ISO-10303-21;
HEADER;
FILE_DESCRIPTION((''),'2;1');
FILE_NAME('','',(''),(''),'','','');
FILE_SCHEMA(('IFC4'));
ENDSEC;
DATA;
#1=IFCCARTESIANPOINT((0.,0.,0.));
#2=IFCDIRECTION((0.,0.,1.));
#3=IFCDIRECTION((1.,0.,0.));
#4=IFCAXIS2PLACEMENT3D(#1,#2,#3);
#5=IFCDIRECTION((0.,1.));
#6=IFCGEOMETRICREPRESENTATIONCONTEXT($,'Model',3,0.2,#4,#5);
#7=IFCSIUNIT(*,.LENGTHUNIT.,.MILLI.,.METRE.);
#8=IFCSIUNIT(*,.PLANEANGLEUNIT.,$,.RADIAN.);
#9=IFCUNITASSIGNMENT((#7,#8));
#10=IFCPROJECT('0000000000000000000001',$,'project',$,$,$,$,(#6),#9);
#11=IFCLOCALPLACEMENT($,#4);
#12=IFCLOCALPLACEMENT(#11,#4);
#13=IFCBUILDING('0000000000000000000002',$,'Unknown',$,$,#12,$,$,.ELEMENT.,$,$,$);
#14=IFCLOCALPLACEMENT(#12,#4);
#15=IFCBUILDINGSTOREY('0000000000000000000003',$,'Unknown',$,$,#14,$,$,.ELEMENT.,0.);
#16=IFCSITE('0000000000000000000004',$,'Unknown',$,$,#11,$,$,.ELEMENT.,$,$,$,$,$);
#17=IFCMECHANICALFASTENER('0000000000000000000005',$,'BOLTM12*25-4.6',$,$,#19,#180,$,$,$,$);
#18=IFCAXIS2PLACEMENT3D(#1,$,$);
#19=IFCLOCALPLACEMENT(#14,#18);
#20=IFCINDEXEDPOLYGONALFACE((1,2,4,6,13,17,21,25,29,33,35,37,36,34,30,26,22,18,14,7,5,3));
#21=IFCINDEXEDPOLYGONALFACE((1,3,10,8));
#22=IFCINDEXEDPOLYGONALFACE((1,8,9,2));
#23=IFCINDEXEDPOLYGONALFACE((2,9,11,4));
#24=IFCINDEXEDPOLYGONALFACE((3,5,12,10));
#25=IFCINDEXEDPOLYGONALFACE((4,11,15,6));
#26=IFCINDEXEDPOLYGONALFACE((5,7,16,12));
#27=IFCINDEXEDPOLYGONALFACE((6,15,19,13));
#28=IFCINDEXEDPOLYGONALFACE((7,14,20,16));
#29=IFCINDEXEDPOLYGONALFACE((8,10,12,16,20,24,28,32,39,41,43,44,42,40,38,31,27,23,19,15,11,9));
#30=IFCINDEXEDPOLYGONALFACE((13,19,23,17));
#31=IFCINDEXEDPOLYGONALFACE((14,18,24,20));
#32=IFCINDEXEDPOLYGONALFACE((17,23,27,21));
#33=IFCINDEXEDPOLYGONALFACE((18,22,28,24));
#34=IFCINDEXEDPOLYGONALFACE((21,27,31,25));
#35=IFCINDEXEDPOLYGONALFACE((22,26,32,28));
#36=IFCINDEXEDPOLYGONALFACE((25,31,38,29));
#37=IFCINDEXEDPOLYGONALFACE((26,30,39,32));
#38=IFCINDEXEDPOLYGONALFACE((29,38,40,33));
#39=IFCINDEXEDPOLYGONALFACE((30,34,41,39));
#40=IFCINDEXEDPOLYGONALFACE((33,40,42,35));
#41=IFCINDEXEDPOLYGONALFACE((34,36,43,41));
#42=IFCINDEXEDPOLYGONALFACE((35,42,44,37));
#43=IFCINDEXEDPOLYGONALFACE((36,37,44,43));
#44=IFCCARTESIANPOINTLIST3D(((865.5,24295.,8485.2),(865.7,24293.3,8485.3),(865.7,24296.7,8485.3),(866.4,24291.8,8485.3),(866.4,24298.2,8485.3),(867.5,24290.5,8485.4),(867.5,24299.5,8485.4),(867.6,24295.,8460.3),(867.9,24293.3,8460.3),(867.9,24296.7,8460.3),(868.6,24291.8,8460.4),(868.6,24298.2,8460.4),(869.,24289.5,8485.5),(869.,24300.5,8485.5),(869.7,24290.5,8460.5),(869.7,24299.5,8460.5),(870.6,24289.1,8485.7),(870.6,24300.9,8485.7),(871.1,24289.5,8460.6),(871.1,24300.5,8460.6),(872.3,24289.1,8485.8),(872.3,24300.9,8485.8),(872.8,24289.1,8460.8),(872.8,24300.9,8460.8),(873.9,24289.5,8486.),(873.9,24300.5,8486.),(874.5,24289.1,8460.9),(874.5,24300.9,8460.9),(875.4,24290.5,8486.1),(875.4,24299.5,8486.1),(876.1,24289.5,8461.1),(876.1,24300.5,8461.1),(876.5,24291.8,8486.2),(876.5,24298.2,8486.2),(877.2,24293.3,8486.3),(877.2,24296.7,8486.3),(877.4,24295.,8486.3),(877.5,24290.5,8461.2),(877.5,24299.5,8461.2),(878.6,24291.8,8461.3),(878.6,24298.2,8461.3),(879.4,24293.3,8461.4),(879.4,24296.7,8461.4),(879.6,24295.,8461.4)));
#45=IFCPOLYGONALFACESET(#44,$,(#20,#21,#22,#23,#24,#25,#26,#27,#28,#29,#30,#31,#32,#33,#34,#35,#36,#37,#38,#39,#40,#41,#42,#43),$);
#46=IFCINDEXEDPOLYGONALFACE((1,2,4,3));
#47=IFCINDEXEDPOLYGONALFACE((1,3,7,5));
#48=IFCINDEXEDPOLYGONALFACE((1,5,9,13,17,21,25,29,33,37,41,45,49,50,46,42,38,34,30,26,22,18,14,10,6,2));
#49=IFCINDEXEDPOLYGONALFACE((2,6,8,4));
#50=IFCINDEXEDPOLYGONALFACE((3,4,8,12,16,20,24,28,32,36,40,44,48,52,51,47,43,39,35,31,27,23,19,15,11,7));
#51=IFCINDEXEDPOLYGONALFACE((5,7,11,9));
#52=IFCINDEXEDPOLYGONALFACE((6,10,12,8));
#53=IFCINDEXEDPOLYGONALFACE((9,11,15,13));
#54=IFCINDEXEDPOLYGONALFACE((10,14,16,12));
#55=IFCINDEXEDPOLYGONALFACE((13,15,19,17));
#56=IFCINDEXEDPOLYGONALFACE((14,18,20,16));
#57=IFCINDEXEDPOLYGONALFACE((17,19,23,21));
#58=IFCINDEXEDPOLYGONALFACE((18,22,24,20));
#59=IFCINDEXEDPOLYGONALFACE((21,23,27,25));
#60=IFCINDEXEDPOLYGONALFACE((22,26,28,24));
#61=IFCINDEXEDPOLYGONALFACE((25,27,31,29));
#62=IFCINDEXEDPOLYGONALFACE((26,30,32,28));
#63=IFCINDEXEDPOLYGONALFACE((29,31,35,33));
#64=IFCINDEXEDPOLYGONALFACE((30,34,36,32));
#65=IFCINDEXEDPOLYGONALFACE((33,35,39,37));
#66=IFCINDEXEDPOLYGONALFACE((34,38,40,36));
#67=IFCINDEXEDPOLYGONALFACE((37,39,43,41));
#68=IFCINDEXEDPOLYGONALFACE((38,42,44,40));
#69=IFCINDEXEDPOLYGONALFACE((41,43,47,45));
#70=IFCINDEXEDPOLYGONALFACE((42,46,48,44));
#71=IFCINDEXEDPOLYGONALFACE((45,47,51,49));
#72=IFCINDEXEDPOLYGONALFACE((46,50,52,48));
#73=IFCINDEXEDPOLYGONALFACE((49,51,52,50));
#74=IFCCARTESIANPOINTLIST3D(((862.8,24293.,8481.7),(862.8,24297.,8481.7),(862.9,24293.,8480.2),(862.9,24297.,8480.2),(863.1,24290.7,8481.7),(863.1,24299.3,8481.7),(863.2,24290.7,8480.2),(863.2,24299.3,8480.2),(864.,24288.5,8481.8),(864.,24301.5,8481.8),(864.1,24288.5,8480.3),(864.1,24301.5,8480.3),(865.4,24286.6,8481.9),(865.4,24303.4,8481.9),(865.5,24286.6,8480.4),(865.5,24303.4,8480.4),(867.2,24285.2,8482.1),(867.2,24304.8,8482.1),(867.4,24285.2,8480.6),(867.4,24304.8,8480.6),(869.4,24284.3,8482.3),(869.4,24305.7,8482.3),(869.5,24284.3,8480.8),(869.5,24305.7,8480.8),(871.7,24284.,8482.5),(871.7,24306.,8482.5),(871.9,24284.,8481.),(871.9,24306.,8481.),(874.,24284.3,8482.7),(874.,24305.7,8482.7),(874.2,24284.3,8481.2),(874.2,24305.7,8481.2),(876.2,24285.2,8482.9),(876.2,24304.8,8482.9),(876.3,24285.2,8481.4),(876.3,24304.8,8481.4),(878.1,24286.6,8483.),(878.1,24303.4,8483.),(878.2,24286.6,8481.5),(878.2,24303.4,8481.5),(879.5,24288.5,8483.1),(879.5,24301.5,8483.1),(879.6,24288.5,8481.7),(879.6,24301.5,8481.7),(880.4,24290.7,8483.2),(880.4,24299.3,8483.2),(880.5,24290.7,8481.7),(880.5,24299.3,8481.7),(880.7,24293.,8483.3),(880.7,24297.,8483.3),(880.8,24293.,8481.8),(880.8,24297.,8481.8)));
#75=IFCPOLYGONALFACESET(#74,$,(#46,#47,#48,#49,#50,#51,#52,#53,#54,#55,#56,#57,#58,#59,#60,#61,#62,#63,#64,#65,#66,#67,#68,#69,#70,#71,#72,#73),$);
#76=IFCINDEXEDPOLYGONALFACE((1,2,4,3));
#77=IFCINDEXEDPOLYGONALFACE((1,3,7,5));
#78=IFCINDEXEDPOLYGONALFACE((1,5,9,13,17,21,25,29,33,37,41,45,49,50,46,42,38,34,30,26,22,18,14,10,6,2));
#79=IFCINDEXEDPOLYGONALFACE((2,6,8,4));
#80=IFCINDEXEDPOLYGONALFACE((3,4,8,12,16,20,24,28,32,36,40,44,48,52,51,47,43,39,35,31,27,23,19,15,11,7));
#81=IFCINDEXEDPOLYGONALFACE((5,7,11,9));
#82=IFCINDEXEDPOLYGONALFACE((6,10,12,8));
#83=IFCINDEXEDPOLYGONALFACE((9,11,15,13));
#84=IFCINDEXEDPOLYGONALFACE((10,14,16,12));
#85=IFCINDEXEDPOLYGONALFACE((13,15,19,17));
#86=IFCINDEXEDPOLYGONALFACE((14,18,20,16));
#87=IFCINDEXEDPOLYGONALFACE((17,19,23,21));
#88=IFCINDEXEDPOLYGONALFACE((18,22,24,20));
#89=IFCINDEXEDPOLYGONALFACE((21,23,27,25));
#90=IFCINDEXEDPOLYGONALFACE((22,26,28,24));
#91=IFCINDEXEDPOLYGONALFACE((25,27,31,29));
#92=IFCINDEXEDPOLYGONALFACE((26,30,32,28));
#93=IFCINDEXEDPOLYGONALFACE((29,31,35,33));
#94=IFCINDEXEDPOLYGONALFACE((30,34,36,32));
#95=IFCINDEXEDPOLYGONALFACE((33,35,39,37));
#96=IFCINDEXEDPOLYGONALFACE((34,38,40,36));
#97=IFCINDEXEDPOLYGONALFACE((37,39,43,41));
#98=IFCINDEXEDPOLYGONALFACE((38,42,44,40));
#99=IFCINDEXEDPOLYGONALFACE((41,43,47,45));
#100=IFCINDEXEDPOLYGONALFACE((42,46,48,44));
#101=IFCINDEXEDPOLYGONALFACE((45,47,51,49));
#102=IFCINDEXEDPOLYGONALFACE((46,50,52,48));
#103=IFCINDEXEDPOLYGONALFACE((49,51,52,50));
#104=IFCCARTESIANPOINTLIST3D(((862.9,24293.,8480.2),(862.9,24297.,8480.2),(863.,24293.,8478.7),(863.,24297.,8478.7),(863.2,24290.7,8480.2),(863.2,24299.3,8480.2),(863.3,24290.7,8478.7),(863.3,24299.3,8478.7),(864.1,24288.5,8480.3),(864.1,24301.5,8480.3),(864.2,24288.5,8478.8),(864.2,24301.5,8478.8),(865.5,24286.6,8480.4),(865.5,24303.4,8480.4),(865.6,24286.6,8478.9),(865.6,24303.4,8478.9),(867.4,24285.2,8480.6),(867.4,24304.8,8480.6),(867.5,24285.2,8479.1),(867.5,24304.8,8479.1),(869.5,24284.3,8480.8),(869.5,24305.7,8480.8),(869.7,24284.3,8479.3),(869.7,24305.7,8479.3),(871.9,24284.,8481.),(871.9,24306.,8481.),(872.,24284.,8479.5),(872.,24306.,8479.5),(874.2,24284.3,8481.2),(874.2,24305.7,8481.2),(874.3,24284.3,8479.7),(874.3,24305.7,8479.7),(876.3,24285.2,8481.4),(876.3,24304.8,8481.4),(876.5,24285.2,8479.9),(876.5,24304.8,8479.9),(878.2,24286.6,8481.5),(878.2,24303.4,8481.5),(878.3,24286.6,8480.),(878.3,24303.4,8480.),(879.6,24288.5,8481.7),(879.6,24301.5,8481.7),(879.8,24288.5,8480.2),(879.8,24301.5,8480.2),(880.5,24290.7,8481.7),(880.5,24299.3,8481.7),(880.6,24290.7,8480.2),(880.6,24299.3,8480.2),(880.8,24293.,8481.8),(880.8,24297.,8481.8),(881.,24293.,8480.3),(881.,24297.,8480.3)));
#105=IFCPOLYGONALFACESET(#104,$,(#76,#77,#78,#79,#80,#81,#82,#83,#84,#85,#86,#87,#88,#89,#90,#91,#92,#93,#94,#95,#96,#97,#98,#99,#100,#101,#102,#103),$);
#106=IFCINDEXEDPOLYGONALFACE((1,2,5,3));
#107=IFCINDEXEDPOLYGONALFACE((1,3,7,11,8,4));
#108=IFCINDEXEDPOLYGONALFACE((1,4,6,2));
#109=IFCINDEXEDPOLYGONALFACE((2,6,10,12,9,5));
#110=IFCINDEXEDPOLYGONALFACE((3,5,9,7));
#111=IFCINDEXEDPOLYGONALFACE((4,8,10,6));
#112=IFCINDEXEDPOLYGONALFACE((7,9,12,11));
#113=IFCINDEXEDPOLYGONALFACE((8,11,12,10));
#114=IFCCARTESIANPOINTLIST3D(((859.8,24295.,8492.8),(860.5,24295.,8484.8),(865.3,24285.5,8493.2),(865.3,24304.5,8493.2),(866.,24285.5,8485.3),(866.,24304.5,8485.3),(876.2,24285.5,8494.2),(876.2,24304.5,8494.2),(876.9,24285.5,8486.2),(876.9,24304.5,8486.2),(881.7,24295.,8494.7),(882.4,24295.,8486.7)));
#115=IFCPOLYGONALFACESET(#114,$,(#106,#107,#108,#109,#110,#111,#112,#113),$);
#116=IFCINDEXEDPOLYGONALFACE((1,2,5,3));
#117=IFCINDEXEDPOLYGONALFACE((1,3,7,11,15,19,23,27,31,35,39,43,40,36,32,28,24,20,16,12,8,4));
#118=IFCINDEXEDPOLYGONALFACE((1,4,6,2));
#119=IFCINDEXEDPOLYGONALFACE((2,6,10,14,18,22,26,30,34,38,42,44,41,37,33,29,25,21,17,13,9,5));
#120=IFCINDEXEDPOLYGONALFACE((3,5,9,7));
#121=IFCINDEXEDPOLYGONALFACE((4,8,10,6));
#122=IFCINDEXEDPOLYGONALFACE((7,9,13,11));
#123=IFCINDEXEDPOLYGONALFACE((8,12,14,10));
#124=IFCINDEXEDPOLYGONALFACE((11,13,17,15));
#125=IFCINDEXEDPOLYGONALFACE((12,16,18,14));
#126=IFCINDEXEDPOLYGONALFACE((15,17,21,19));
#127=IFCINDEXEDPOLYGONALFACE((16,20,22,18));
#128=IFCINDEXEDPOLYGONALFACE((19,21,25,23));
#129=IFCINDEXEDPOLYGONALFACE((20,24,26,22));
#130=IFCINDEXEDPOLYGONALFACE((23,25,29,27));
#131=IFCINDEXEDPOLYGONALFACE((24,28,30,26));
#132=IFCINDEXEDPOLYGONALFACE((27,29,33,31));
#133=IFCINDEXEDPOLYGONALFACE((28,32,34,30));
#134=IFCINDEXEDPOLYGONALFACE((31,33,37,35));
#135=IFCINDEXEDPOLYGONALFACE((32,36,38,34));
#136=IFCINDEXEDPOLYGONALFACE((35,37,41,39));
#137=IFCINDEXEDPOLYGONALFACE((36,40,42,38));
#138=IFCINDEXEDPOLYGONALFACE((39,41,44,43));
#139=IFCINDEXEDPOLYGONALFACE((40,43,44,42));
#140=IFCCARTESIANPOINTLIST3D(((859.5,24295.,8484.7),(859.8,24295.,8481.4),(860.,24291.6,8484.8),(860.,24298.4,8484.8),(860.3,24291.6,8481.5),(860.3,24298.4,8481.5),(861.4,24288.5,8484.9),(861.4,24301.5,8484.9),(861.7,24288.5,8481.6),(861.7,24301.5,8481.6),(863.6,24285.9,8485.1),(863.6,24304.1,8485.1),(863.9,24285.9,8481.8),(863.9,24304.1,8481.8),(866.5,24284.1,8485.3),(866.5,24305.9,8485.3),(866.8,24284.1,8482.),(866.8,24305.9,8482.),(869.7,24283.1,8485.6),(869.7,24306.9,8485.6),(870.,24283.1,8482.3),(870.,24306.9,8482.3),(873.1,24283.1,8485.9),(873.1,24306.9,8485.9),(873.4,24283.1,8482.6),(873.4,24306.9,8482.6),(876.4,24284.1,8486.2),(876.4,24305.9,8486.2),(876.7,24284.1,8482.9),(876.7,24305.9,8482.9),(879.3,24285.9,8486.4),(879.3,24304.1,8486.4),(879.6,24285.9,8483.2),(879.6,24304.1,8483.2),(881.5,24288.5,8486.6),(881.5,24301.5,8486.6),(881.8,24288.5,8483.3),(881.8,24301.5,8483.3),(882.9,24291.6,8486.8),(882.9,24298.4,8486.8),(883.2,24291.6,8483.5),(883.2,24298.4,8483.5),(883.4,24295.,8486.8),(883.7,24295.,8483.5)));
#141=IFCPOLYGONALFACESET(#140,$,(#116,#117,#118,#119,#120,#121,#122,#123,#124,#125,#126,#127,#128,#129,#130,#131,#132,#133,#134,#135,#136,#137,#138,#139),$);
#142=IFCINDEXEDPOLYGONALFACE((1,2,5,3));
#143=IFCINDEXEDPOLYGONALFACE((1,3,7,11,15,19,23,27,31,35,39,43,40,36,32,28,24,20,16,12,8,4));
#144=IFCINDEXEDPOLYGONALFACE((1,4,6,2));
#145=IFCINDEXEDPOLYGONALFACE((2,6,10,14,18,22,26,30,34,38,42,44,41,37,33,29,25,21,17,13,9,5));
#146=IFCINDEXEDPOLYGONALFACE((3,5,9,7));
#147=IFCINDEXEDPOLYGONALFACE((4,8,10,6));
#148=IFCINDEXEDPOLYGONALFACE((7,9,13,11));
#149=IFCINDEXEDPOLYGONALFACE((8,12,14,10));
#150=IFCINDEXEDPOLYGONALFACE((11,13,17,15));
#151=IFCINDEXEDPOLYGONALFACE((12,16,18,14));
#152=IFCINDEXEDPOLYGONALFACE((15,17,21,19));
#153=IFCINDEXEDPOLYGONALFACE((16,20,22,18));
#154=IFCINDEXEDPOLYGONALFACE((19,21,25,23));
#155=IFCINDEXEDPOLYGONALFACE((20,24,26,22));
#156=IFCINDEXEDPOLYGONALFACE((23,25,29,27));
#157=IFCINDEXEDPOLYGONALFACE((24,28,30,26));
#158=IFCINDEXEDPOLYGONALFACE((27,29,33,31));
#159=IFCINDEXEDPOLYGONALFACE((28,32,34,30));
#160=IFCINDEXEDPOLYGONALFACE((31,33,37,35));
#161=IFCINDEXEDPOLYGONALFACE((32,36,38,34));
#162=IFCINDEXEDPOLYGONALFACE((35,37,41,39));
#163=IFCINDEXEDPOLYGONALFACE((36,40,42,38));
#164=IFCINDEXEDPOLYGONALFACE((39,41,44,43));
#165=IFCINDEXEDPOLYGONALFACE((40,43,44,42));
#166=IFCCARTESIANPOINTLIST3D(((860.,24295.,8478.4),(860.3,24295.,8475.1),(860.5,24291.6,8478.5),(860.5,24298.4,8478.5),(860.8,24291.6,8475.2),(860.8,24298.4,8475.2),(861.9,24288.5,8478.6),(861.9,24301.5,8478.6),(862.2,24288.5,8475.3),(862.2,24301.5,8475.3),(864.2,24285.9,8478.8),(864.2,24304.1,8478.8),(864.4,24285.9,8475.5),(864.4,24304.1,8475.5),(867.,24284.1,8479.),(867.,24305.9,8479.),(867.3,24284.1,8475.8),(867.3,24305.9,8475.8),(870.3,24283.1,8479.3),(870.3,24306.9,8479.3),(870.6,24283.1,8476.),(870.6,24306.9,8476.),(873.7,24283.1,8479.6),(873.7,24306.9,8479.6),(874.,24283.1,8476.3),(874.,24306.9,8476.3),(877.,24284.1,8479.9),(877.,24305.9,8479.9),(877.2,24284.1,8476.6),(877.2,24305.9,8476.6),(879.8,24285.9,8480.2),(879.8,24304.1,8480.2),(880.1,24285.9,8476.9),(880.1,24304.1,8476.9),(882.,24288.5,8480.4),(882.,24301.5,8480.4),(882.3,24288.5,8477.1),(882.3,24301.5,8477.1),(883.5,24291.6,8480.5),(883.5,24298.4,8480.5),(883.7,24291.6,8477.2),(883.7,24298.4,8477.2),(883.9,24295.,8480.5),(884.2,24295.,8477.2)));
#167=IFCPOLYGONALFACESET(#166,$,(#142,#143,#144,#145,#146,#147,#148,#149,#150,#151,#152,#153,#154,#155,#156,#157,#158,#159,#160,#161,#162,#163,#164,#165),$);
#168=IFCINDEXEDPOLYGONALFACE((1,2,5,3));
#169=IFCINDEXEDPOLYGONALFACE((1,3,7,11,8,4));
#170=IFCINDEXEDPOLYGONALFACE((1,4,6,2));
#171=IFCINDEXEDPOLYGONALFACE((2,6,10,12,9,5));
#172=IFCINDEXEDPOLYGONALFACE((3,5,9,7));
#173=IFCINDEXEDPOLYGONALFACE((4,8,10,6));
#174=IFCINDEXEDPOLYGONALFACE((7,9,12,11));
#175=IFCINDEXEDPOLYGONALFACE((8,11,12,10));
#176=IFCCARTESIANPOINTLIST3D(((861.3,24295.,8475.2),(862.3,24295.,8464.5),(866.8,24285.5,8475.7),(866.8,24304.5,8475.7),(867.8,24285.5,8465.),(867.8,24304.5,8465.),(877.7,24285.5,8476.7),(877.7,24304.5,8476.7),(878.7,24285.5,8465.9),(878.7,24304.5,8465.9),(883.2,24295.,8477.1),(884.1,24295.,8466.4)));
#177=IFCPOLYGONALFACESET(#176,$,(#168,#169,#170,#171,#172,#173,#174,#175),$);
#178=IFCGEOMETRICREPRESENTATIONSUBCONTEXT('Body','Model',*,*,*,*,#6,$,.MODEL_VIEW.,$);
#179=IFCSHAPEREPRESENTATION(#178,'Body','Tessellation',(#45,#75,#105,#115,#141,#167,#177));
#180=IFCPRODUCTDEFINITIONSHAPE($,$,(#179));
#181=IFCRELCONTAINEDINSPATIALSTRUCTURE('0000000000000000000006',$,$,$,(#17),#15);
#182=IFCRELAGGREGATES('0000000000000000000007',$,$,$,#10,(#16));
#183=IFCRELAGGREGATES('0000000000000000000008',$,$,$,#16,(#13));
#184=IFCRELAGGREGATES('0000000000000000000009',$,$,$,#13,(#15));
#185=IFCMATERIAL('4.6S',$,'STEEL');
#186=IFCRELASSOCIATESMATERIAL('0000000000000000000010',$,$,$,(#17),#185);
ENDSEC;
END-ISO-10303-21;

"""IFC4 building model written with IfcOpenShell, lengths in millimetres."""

from ifc_helpers import new_model, si_unit, direction, frame, origin_with_axes, place, context, subcontext, project, spatial, line, arc, indexed_curve, outline, extrude, source, transform, mapped, material, element, save


model = new_model("IFC4")

# Units and contexts
model_context = context("Model", 3, precision=0.2, world=origin_with_axes(), true_north=direction((0.0, 1.0)))
body_context = subcontext(model_context, "Body", "Model", "MODEL_VIEW")
ifc_project = project(units=[si_unit("LENGTHUNIT", "METRE", prefix="MILLI"), si_unit("PLANEANGLEUNIT", "RADIAN")], contexts=[model_context])

# Site, building, storey
site_placement = place(None, origin_with_axes())
site = spatial("IfcSite", under=ifc_project, at=site_placement, Name="Unknown", CompositionType="ELEMENT")
building_placement = place(site_placement, origin_with_axes())
building = spatial("IfcBuilding", under=site, at=building_placement, Name="Unknown", CompositionType="ELEMENT")
storey_placement = place(building_placement, origin_with_axes())
storey = spatial("IfcBuildingStorey", under=building, at=storey_placement, Name="Unknown", CompositionType="ELEMENT", Elevation=0.0)

# Mechanical fastener
ifc_material_1 = material(Name="4.6S", Category="STEEL")
shared_shape_1 = source(origin_with_axes(), body_context, "Body", "SweptSolid", [
    extrude(outline(indexed_curve([(6.0, 0.0), (0.0, 6.0), (-6.0, 0.0), (0.0, -6.0)], segments=[arc(1, 2, 3), arc(3, 4, 1)])), frame((0.0, 0.0, 4.8), z_axis=(0.0, 0.0, -1.0), x_axis=(0.0, 1.0, 0.0)), (0.0, 0.0, 1.0), 25.0),
    extrude(outline(indexed_curve([(0.0, 11.0), (6.4, 8.4), (9.0, 2.0), (9.0, -2.0), (6.4, -8.4), (0.0, -11.0), (-0.8, -11.0), (-9.0, -2.0), (-9.0, 2.0), (-6.4, 8.4)], segments=[arc(1, 2, 3), line(3, 4), arc(4, 5, 6), arc(6, 7, 8), line(8, 9), arc(9, 10, 1)])), frame((0.0, 0.0, 1.5), z_axis=(0.0, 0.0, -1.0), x_axis=(0.0, 1.0, 0.0)), (0.0, 0.0, 1.0), 1.5),
    extrude(outline(indexed_curve([(0.0, 11.0), (6.4, 8.4), (9.0, 2.0), (9.0, -2.0), (6.4, -8.4), (0.0, -11.0), (-0.8, -11.0), (-9.0, -2.0), (-9.0, 2.0), (-6.4, 8.4)], segments=[arc(1, 2, 3), line(3, 4), arc(4, 5, 6), arc(6, 7, 8), line(8, 9), arc(9, 10, 1)])), frame((0.0, 0.0, 0.0), z_axis=(0.0, 0.0, -1.0), x_axis=(0.0, 1.0, 0.0)), (0.0, 0.0, 1.0), 1.5),
    extrude(outline(indexed_curve([(11.0, 0.0), (5.5, 9.5), (-5.5, 9.5), (-11.0, 0.0), (-5.5, -9.5), (5.5, -9.5)], segments=[line(1, 2, 3, 4, 5, 6, 1)])), frame((0.0, 0.0, 12.8), z_axis=(0.0, 0.0, -1.0), x_axis=(0.0, 1.0, 0.0)), (0.0, 0.0, 1.0), 8.0),
    extrude(outline(indexed_curve([(12.0, 0.0), (0.0, 12.0), (-12.0, 0.0), (0.0, -12.0)], segments=[arc(1, 2, 3), arc(3, 4, 1)])), frame((0.0, 0.0, 4.8), z_axis=(0.0, 0.0, -1.0), x_axis=(0.0, 1.0, 0.0)), (0.0, 0.0, 1.0), 3.3),
    extrude(outline(indexed_curve([(12.0, 0.0), (0.0, 12.0), (-12.0, 0.0), (0.0, -12.0)], segments=[arc(1, 2, 3), arc(3, 4, 1)])), frame((0.0, 0.0, -1.5), z_axis=(0.0, 0.0, -1.0), x_axis=(0.0, 1.0, 0.0)), (0.0, 0.0, 1.0), 3.3),
    extrude(outline(indexed_curve([(11.0, 0.0), (5.5, 9.5), (-5.5, 9.5), (-11.0, 0.0), (-5.5, -9.5), (5.5, -9.5)], segments=[line(1, 2, 3, 4, 5, 6, 1)])), frame((0.0, 0.0, -4.8), z_axis=(0.0, 0.0, -1.0), x_axis=(0.0, 1.0, 0.0)), (0.0, 0.0, 1.0), 10.8),
])
for number, where, z_axis, x_axis, name in (
    (1, (871.9, 24295.0, 8481.0), (-0.08716, 0.0, 0.996194), (0.0, 1.0, 0.0), "BOLTM12*25-4.6"),
):
    element("IfcMechanicalFastener", number, at=place(storey_placement, frame(where, z_axis=z_axis, x_axis=x_axis)), inside=storey, material=ifc_material_1, Name=name, context=body_context, shape_type="MappedRepresentation", body=[
        mapped(shared_shape_1, transform((0.0, 0.0, 0.0))),
    ])

save(model, "model.ifc")
